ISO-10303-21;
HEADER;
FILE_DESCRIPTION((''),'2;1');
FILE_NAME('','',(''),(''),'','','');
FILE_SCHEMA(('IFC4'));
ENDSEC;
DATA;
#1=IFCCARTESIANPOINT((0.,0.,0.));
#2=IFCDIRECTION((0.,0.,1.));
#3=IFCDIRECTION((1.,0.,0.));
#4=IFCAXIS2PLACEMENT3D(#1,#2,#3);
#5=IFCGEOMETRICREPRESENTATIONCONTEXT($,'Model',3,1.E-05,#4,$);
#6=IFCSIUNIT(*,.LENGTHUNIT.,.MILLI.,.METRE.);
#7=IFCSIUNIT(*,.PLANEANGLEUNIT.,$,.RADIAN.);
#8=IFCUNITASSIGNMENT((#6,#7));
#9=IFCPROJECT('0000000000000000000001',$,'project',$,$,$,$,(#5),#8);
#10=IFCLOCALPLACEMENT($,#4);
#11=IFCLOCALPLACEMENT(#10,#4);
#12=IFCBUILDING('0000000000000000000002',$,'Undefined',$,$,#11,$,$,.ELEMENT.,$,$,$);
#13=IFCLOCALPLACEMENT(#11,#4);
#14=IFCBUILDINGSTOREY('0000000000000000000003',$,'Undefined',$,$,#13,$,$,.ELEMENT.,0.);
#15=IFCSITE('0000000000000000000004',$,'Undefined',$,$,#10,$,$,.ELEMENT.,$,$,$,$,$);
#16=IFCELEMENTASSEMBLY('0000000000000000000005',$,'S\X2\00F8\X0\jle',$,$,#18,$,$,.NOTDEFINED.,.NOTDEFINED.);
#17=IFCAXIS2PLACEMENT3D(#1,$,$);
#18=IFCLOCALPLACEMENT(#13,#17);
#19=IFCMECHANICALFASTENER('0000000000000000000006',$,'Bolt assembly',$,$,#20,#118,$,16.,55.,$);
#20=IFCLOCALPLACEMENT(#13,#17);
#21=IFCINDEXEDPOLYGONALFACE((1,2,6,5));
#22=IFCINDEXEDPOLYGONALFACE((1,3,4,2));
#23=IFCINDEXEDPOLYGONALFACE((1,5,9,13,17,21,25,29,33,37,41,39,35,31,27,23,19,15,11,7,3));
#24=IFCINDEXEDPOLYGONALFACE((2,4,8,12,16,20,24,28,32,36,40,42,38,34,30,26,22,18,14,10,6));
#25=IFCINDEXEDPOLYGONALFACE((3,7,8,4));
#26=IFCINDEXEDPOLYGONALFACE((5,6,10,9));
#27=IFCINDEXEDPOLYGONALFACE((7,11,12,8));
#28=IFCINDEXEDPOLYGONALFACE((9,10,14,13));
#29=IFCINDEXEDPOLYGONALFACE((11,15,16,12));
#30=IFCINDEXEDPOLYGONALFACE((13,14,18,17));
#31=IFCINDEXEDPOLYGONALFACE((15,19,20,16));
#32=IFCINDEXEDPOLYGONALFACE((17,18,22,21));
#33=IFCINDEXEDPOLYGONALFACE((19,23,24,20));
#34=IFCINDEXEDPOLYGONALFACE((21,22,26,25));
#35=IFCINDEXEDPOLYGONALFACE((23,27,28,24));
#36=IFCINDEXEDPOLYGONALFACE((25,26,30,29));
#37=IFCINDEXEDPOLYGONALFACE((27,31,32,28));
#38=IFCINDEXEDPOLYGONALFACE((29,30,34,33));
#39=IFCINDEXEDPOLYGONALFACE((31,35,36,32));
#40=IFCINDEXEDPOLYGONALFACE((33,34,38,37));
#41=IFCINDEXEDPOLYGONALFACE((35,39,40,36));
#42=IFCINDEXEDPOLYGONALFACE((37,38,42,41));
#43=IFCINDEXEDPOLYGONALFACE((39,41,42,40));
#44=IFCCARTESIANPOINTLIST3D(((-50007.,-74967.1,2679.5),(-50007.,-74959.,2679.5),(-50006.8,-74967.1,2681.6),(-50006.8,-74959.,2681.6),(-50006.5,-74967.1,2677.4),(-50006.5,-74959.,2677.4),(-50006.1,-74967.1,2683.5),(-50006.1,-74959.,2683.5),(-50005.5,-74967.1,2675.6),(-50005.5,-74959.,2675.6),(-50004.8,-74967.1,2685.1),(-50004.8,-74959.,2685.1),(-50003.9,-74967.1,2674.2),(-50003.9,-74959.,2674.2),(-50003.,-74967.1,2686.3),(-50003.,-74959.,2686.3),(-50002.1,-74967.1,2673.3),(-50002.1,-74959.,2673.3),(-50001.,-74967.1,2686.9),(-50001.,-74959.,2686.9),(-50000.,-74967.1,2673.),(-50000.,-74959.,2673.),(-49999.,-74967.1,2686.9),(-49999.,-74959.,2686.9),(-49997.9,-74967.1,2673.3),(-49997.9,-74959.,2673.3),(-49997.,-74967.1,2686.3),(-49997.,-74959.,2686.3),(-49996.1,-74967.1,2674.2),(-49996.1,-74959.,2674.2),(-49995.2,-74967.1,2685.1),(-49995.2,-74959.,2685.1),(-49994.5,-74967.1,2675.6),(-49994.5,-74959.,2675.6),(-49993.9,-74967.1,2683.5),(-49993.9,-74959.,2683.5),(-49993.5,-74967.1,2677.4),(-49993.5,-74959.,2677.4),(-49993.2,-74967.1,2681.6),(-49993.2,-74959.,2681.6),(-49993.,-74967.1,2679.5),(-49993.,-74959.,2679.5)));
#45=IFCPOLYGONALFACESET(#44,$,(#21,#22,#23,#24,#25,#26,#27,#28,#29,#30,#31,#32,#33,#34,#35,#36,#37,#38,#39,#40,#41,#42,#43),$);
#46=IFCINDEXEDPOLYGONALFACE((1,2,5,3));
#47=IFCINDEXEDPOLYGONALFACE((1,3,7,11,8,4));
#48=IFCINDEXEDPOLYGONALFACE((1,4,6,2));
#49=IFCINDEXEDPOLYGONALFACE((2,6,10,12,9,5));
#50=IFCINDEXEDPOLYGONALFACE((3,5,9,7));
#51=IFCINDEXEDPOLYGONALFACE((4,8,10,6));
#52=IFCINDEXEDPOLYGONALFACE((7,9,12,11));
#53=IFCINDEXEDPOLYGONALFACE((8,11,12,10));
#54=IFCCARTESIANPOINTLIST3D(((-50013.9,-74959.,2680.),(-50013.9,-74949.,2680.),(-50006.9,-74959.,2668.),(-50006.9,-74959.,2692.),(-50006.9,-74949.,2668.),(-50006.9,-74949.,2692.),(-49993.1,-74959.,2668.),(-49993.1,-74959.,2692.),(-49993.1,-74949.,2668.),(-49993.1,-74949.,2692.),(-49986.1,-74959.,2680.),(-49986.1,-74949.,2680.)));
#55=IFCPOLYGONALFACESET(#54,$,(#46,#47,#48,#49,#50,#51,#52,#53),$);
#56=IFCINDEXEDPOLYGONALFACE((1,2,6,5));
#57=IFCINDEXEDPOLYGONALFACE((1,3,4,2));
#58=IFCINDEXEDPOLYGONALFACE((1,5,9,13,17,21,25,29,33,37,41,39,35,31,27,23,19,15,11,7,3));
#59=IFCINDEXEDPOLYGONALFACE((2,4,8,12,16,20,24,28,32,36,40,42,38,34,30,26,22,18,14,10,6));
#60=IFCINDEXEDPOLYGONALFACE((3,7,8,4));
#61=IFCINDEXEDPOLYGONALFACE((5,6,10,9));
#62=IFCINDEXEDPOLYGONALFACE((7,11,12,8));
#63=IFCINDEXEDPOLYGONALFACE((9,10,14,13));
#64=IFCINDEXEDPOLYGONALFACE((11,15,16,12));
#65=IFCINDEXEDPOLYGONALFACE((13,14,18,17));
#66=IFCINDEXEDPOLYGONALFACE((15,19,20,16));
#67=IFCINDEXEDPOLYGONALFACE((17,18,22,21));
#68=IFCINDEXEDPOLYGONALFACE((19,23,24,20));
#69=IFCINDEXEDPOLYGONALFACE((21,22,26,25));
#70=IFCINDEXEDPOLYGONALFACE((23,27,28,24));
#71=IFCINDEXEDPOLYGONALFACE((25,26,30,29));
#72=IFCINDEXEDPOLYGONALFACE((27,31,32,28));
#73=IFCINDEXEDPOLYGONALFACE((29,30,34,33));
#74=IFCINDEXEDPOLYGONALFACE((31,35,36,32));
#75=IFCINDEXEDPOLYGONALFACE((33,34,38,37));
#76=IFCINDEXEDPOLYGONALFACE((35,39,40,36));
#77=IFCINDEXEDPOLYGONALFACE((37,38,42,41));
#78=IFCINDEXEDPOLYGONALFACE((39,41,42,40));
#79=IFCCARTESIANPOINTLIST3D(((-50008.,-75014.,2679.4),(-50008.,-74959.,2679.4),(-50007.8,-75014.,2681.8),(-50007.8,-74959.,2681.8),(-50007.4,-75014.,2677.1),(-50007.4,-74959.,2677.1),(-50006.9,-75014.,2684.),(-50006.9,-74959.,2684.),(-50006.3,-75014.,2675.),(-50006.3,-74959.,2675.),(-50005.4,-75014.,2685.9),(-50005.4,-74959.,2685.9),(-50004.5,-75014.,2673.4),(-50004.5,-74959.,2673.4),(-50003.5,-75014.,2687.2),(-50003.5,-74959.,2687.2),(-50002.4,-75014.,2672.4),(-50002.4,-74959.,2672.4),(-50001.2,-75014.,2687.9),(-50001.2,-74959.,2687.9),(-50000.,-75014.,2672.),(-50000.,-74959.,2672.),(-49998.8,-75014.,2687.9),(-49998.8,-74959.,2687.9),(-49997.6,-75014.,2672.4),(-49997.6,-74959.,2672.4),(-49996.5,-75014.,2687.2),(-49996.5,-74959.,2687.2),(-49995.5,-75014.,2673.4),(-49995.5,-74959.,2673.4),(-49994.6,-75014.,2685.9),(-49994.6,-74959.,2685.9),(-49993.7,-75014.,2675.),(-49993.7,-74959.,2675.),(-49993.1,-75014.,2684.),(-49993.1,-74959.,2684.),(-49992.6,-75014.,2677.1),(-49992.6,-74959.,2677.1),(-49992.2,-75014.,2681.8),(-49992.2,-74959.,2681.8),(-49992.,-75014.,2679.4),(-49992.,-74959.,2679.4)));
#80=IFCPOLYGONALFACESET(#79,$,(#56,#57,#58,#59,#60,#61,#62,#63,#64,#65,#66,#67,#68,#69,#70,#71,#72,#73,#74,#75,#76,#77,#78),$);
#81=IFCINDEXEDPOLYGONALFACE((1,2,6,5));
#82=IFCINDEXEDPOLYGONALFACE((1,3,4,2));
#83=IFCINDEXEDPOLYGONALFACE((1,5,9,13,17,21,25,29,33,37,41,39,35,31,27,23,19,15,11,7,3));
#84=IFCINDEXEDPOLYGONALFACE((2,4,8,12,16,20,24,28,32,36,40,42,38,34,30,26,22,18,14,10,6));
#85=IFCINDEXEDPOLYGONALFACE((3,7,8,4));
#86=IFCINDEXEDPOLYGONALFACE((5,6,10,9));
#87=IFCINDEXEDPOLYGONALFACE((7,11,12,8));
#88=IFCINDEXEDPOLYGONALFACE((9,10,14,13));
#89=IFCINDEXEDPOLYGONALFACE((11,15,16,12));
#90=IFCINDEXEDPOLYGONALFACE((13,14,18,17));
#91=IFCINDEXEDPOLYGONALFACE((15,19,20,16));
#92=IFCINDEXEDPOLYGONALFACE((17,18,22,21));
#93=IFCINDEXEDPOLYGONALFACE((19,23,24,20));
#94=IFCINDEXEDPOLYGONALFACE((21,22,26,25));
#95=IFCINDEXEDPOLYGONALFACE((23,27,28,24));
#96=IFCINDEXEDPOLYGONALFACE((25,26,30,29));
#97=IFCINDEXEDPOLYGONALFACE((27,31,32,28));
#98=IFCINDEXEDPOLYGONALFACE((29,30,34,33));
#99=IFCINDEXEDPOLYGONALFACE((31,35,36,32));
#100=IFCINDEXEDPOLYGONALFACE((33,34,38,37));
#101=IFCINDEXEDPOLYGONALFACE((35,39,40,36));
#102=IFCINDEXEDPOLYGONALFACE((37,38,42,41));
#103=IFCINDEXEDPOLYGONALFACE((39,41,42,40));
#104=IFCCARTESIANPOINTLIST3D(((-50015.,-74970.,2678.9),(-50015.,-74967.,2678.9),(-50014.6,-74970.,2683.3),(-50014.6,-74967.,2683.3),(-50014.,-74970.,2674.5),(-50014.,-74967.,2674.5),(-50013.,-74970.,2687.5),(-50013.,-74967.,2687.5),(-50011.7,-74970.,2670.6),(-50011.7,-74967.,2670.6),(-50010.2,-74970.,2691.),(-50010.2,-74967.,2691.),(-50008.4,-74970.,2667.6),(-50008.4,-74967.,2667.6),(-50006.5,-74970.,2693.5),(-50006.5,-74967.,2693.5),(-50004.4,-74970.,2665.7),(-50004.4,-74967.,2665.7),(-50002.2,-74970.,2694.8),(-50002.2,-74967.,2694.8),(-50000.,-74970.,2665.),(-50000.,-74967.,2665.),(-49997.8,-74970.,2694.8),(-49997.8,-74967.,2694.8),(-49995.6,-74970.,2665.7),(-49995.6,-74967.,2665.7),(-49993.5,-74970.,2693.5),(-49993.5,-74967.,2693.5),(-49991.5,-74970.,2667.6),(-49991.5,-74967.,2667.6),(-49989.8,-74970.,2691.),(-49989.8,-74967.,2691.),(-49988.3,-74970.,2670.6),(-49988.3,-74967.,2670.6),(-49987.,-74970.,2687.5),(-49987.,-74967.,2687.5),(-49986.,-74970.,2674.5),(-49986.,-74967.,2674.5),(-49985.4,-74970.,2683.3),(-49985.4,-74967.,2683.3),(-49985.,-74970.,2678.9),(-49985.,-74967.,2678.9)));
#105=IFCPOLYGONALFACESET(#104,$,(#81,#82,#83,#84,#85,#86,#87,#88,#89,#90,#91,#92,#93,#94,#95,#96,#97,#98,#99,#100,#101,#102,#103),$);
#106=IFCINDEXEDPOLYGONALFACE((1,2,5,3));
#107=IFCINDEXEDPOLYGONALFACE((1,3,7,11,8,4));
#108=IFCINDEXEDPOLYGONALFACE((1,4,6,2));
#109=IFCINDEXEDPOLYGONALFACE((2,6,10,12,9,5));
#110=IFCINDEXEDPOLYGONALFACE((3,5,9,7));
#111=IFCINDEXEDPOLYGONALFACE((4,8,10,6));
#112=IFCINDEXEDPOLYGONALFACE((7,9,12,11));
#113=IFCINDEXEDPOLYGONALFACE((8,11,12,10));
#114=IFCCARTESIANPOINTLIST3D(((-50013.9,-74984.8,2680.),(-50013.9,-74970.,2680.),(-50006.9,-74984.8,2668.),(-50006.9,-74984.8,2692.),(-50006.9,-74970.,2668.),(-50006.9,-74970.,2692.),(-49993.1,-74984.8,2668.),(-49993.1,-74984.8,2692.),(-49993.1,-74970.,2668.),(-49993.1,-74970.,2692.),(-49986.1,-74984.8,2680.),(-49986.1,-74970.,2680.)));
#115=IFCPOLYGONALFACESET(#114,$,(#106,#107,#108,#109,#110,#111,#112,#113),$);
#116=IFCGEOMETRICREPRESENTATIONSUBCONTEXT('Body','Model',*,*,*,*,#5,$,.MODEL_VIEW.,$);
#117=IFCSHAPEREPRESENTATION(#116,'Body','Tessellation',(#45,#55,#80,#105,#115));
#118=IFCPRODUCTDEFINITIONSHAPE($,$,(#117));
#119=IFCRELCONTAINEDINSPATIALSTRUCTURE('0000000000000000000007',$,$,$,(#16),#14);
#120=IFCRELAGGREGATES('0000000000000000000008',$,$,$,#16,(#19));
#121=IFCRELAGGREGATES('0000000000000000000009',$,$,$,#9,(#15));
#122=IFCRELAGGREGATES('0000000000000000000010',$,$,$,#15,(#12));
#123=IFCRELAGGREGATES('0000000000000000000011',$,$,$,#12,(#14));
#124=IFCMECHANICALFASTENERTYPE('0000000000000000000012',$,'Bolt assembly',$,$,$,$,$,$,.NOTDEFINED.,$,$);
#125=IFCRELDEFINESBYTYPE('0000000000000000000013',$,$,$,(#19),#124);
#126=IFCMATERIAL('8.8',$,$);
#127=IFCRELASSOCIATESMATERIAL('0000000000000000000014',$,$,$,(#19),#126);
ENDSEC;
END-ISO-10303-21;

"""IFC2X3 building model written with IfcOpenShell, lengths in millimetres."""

from ifc_helpers import new_model, si_unit, frame, origin_with_axes, origin_2d_with_axis, place, context, subcontext, project, spatial, polyline, circle, outline, extrude, source, transform, mapped, material, type_object, element, aggregate, save


model = new_model("IFC2X3")

# Units and contexts
model_context = context("Model", 3, precision=1e-05, world=origin_with_axes())
body_context = subcontext(model_context, "Body", "Model", "MODEL_VIEW")
ifc_project = project(units=[si_unit("LENGTHUNIT", "METRE", prefix="MILLI"), si_unit("PLANEANGLEUNIT", "RADIAN")], contexts=[model_context])

# Site, building, storey
site_placement = place(None, origin_with_axes())
site = spatial("IfcSite", under=ifc_project, at=site_placement, Name="Undefined", CompositionType="ELEMENT")
building_placement = place(site_placement, origin_with_axes())
building = spatial("IfcBuilding", under=site, at=building_placement, Name="Undefined", CompositionType="ELEMENT")
storey_placement = place(building_placement, origin_with_axes())
storey = spatial("IfcBuildingStorey", under=building, at=storey_placement, Name="Undefined", CompositionType="ELEMENT", Elevation=0.0)

# Element assembly
assembly_1_placement = place(storey_placement, origin_with_axes())
assembly_1 = element("IfcElementAssembly", 1, at=assembly_1_placement, inside=storey, Name="Søjle", AssemblyPlace="NOTDEFINED", PredefinedType="NOTDEFINED")

# Mechanical fastener
ifc_material_1 = material(Name="8.8")
mechanical_fastener_type = type_object("IfcMechanicalFastenerType", Name="Bolt assembly")
shared_shape_1 = source(origin_with_axes(), body_context, "Body", "SweptSolid", [
    extrude(circle(Radius=7.0, at=origin_2d_with_axis()), frame((0.0, 0.0, 0.0), z_axis=(0.0, 1.0, 0.0), x_axis=(1.0, 0.0, 0.0)), (0.0, 0.0, 1.0), 8.1),
    extrude(outline(polyline([(12.0, -6.9), (12.0, 6.9), (0.0, 13.9), (-12.0, 6.9), (-12.0, -6.9), (0.0, -13.9), (12.0, -6.9)])), frame((0.0, -10.0, 0.0), z_axis=(0.0, 1.0, 0.0), x_axis=(1.0, 0.0, 0.0)), (0.0, 0.0, 1.0), 10.0),
    extrude(circle(Radius=8.0, at=origin_2d_with_axis()), frame((0.0, 0.0, 0.0), z_axis=(0.0, 1.0, 0.0), x_axis=(1.0, 0.0, 0.0)), (0.0, 0.0, 1.0), 55.0),
    extrude(circle(Radius=15.0, at=origin_2d_with_axis()), frame((0.0, 8.0, 0.0), z_axis=(0.0, 1.0, 0.0), x_axis=(1.0, 0.0, 0.0)), (0.0, 0.0, 1.0), 3.0),
    extrude(outline(polyline([(12.0, -6.9), (12.0, 6.9), (0.0, 13.9), (-12.0, 6.9), (-12.0, -6.9), (0.0, -13.9), (12.0, -6.9)])), frame((0.0, 11.0, 0.0), z_axis=(0.0, 1.0, 0.0), x_axis=(1.0, 0.0, 0.0)), (0.0, 0.0, 1.0), 14.8),
])
mechanical_fastener_1_placement = place(assembly_1_placement, frame((-50000.0, -74959.0, 2680.0), z_axis=(-1.0, 0.0, 0.0), x_axis=(0.0, 0.0, -1.0)))
mechanical_fastener_1 = element("IfcMechanicalFastener", 2, at=mechanical_fastener_1_placement, type_object=mechanical_fastener_type, material=ifc_material_1, Name="Bolt assembly", NominalDiameter=16.0, NominalLength=55.0, context=body_context, shape_type="MappedRepresentation", body=[
    mapped(shared_shape_1, transform((0.0, 0.0, 0.0))),
])
aggregate(assembly_1, [mechanical_fastener_1])

save(model, "model.ifc")
